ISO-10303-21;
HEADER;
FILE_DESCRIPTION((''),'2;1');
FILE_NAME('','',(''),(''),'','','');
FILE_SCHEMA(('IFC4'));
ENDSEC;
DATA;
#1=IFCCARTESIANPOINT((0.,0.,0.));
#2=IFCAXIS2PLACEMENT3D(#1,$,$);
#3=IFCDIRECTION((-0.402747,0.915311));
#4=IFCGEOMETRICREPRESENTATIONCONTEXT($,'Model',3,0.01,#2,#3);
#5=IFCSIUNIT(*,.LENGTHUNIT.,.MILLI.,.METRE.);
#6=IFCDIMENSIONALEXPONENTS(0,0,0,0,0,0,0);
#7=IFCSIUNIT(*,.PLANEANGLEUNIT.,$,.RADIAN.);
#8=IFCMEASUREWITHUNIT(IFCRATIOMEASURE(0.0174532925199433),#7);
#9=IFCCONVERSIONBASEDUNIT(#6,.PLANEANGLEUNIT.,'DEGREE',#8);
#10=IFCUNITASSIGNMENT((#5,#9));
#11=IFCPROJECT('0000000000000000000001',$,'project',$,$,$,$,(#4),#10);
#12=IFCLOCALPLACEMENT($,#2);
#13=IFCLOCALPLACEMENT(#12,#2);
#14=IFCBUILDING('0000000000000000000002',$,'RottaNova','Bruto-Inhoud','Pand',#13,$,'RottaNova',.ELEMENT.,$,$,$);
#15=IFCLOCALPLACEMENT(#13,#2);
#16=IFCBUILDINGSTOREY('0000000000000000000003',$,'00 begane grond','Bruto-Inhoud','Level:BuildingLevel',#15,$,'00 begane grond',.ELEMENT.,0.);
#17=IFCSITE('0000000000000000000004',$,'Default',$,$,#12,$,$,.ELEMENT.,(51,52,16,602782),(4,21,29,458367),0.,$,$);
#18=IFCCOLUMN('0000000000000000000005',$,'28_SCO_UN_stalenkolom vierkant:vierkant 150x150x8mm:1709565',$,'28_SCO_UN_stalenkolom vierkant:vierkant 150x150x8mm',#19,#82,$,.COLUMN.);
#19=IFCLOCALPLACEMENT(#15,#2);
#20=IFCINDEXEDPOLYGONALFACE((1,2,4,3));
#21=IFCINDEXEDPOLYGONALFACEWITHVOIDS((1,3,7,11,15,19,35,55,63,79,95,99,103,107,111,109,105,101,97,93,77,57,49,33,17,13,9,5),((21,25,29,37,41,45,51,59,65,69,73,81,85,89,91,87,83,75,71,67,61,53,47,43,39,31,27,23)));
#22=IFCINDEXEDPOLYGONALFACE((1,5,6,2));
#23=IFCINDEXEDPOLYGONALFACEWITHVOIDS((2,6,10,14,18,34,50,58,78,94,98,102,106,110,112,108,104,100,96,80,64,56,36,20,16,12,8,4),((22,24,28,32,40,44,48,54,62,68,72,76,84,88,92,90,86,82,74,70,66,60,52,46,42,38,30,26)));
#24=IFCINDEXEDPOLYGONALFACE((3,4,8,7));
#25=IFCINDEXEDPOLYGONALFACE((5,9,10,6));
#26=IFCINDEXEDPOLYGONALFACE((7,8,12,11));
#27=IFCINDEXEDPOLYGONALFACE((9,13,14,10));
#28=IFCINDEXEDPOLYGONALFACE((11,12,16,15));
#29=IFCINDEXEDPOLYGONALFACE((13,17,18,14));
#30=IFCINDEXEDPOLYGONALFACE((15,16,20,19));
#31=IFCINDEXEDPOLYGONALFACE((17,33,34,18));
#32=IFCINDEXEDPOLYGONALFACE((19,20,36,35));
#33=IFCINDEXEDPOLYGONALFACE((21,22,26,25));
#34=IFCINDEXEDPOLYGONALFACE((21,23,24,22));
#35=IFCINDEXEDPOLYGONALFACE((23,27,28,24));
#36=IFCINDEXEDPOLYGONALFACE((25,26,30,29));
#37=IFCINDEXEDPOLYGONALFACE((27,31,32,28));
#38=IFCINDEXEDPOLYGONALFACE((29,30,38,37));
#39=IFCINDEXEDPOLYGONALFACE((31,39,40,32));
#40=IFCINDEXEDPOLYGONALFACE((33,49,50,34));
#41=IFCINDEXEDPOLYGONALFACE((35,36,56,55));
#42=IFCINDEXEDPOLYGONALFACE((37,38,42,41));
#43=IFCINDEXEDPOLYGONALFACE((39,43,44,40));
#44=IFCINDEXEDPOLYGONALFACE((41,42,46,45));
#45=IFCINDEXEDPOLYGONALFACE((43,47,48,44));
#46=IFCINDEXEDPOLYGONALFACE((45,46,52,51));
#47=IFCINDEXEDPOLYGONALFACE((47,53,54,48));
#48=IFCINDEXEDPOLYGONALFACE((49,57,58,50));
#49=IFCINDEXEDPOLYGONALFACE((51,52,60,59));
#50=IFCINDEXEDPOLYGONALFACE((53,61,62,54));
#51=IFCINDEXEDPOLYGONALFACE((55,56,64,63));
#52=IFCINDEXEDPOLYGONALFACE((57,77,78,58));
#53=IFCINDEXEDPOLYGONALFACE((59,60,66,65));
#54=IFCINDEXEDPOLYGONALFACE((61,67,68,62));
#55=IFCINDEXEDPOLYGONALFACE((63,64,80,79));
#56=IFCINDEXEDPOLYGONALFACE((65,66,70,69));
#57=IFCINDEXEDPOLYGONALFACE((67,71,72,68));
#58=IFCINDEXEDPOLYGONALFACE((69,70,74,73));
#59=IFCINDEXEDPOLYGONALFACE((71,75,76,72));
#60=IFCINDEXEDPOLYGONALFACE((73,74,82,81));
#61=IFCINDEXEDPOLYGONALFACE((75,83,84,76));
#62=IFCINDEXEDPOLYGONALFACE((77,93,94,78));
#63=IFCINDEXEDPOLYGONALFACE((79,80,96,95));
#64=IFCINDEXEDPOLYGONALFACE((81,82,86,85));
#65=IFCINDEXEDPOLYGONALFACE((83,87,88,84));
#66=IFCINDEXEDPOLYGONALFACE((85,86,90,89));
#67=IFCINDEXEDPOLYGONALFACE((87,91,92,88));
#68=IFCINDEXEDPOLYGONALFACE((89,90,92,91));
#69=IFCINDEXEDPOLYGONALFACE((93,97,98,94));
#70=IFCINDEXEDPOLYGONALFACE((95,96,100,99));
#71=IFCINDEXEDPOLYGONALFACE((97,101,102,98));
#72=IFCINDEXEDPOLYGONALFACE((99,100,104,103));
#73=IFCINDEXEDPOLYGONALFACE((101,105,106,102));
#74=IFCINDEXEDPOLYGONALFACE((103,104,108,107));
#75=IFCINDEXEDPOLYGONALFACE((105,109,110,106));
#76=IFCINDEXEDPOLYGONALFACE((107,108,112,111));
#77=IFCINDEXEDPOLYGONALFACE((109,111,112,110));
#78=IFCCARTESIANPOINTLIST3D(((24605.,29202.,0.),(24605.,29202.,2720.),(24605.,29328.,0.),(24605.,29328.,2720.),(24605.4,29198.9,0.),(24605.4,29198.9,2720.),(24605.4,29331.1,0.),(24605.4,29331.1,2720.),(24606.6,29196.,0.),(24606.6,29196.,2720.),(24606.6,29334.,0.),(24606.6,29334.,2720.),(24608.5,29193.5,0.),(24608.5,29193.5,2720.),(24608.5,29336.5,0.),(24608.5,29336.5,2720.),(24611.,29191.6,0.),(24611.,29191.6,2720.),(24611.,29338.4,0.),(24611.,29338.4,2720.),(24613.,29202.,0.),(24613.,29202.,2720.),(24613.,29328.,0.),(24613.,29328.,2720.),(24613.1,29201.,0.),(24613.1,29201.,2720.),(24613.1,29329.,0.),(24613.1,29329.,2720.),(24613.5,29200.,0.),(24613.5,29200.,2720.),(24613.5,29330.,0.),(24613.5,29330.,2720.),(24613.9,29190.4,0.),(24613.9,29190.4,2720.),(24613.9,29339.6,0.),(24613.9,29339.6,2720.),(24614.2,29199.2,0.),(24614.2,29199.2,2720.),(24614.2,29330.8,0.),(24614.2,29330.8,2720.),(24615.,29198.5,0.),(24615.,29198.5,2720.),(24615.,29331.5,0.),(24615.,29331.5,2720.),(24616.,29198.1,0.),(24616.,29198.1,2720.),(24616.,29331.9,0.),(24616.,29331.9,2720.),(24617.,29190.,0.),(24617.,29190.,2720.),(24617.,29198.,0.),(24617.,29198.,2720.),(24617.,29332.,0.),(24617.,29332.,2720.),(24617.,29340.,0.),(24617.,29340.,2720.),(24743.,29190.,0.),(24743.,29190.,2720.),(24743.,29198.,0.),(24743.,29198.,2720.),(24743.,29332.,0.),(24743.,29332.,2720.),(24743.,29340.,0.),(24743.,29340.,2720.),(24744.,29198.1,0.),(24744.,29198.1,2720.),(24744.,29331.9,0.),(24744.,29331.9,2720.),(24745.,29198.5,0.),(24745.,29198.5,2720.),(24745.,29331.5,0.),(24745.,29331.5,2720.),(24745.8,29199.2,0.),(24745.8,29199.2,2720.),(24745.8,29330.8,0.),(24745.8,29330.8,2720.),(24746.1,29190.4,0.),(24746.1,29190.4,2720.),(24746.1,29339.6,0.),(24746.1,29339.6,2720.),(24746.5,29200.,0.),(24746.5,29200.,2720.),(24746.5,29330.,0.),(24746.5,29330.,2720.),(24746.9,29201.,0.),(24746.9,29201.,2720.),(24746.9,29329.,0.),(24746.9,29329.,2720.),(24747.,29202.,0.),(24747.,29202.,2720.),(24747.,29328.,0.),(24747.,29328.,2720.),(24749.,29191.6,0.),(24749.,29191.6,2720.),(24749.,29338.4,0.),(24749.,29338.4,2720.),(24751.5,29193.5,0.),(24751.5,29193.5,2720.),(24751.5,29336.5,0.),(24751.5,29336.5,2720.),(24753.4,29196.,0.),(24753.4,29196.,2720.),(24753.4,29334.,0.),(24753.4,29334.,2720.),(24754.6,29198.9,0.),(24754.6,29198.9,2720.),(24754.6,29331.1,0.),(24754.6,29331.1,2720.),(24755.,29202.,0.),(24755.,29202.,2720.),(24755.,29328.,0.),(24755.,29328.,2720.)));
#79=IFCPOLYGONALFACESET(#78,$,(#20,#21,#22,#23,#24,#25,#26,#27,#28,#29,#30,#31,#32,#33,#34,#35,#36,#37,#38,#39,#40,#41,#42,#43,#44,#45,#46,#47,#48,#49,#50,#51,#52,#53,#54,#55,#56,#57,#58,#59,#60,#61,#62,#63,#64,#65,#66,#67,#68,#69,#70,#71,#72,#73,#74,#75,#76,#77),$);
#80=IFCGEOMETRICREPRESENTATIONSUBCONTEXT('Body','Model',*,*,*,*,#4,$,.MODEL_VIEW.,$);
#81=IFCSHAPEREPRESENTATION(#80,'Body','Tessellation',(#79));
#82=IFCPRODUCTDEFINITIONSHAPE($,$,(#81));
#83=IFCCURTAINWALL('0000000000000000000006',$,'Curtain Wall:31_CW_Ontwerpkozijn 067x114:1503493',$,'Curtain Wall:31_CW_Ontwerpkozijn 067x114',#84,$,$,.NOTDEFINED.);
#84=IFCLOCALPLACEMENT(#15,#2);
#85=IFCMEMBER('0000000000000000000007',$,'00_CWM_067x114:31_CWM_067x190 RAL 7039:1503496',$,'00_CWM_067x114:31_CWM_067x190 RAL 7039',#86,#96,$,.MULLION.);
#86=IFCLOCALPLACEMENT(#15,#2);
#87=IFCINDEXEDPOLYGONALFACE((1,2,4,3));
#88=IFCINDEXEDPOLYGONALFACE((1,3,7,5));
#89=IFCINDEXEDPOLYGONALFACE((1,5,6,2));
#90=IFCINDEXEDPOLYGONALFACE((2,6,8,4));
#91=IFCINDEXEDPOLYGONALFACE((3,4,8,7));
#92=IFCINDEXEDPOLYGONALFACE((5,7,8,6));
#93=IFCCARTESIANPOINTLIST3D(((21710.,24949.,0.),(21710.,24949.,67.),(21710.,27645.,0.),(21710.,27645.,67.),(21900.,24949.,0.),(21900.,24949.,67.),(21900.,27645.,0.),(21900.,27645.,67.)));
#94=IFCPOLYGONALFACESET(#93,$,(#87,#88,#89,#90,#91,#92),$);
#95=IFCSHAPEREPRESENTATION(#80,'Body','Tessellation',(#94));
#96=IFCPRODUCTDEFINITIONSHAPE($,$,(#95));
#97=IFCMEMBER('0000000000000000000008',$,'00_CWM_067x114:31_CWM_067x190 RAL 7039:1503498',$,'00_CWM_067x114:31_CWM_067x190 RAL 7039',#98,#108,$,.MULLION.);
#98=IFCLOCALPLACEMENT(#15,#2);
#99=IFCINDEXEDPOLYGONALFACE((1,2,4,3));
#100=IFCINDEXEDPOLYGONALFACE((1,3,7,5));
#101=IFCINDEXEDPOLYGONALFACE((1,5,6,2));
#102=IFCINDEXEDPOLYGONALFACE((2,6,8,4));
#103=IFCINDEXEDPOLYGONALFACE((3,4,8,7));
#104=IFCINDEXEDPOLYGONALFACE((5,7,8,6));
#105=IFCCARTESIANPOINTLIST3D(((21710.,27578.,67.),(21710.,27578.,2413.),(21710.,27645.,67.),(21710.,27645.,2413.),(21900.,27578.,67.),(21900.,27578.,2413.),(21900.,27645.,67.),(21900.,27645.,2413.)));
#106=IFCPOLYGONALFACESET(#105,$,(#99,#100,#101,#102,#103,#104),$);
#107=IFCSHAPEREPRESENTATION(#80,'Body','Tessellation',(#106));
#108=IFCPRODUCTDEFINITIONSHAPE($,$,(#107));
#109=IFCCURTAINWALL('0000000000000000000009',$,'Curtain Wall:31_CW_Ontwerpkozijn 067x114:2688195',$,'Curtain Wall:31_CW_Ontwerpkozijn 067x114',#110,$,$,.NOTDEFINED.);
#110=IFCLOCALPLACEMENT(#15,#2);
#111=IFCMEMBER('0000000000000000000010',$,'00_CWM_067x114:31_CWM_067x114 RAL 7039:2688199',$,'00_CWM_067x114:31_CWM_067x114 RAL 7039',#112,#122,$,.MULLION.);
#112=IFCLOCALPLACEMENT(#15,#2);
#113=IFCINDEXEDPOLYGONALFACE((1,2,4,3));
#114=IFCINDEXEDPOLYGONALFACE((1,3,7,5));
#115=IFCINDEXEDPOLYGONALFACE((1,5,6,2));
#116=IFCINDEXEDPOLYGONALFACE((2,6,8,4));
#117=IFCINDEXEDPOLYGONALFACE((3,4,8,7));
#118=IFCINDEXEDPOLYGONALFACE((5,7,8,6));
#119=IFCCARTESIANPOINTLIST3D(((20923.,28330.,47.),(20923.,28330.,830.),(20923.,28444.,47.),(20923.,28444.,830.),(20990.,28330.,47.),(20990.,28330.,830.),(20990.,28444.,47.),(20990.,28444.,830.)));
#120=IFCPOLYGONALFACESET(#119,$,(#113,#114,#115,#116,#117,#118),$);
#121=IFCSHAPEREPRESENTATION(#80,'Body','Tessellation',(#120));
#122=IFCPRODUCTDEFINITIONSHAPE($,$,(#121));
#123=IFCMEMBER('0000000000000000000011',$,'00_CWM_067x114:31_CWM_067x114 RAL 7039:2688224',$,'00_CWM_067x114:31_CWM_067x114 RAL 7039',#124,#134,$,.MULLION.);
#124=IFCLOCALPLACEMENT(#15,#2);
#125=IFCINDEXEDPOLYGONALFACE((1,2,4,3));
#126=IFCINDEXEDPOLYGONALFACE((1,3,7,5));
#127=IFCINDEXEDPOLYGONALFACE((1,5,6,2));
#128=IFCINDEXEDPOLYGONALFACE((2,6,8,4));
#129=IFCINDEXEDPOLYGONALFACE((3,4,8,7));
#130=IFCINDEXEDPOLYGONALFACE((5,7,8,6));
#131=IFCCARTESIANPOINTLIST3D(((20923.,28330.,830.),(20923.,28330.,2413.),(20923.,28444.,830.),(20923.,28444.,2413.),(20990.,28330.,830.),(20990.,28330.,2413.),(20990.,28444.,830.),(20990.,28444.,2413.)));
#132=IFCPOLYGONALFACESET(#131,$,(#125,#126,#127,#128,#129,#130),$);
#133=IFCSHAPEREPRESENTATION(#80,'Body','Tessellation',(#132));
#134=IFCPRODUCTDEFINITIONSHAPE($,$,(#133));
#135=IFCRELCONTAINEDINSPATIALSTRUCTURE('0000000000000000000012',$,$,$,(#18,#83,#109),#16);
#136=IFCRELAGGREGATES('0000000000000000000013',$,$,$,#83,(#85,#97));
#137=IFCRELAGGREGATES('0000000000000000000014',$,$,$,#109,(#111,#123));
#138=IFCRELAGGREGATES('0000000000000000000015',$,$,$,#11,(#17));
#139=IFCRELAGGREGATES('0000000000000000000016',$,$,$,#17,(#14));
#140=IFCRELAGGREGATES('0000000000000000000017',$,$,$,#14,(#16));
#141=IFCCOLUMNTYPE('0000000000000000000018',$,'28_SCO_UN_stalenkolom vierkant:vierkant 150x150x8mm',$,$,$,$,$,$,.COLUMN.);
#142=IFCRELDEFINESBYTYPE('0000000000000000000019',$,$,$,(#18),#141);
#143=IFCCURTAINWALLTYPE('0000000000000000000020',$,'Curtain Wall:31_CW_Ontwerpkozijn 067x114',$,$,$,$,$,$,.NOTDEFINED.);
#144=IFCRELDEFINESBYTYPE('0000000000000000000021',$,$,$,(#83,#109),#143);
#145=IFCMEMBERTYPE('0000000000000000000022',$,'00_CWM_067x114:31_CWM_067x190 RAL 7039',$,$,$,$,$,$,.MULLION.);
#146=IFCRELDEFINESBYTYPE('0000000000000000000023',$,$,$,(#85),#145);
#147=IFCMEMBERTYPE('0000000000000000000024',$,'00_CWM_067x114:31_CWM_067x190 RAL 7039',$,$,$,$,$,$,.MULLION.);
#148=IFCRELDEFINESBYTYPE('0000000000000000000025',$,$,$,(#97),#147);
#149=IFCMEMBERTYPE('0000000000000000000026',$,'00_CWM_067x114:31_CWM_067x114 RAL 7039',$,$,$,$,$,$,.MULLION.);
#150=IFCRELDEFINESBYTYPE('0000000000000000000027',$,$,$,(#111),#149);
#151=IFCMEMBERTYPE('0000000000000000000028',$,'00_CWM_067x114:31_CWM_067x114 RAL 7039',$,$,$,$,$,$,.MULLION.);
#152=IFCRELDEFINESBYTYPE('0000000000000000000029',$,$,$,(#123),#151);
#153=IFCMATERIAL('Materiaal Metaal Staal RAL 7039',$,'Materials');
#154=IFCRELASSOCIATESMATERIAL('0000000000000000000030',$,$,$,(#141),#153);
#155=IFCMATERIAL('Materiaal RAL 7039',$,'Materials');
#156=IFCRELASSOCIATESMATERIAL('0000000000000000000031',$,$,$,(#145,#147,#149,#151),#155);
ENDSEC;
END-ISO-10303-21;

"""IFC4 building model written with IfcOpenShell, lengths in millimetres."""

from ifc_helpers import new_model, entity, si_unit, converted_unit, direction, frame, frame_2d, origin, origin_2d_with_axis, place, context, subcontext, project, spatial, polyline, circle_curve, parameter, trimmed, segment, composite_curve, rectangle, outline, extrude, source, transform, mapped, material, material_profile, profile_set, type_object, type_shapes, element, aggregate, save


model = new_model("IFC4")

# Units and contexts
model_context = context("Model", 3, precision=0.01, world=origin(), true_north=direction((-0.402747, 0.915311)))
body_context = subcontext(model_context, "Body", "Model", "MODEL_VIEW")
ifc_project = project(units=[si_unit("LENGTHUNIT", "METRE", prefix="MILLI"), converted_unit("PLANEANGLEUNIT", "DEGREE", entity("IfcRatioMeasure", 0.0174532925199433), si_unit("PLANEANGLEUNIT", "RADIAN"), dimensions=[0, 0, 0, 0, 0, 0, 0])], contexts=[model_context])

# Site, building, storey
site_placement = place(None, origin())
site = spatial("IfcSite", under=ifc_project, at=site_placement, Name="Default", CompositionType="ELEMENT", RefLatitude=(51, 52, 16, 602782), RefLongitude=(4, 21, 29, 458367), RefElevation=0.0)
building_placement = place(site_placement, origin())
building = spatial("IfcBuilding", under=site, at=building_placement, Name="RottaNova", Description="Bruto-Inhoud", ObjectType="Pand", LongName="RottaNova", CompositionType="ELEMENT")
storey_placement = place(building_placement, origin())
storey = spatial("IfcBuildingStorey", under=building, at=storey_placement, Name="00 begane grond", Description="Bruto-Inhoud", ObjectType="Level:BuildingLevel", LongName="00 begane grond", CompositionType="ELEMENT", Elevation=0.0)

# Column
ifc_material_1 = material(Name="Materiaal Metaal Staal RAL 7039", Category="Materials")
ifc_material_profile_1 = material_profile(ifc_material_1, outline(composite_curve([segment(trimmed(circle_curve(frame_2d((63.0, -63.0), x_axis=(1.0, 0.0)), 12.0), [parameter(270.0)], [parameter(360.0)], True, "PARAMETER"), True, "CONTINUOUS"), segment(polyline([(75.0, -63.0), (75.0, 63.0)]), True, "CONTINUOUS"), segment(trimmed(circle_curve(frame_2d((63.0, 63.0), x_axis=(1.0, 0.0)), 12.0), [parameter(360.0)], [parameter(90.0)], True, "PARAMETER"), True, "CONTINUOUS"), segment(polyline([(63.0, 75.0), (-63.0, 75.0)]), True, "CONTINUOUS"), segment(trimmed(circle_curve(frame_2d((-63.0, 63.0), x_axis=(1.0, 0.0)), 12.0), [parameter(90.0)], [parameter(180.0)], True, "PARAMETER"), True, "CONTINUOUS"), segment(polyline([(-75.0, 63.0), (-75.0, -63.0)]), True, "CONTINUOUS"), segment(trimmed(circle_curve(frame_2d((-63.0, -63.0), x_axis=(1.0, 0.0)), 12.0), [parameter(180.0)], [parameter(270.0)], True, "PARAMETER"), True, "CONTINUOUS"), segment(polyline([(-63.0, -75.0), (63.0, -75.0)]), True, "CONTINUOUS")], self_intersect=False), holes=[composite_curve([segment(polyline([(-67.0, -63.0), (-67.0, 63.0)]), True, "CONTINUOUS"), segment(trimmed(circle_curve(frame_2d((-63.0, 63.0), x_axis=(1.0, 0.0)), 4.0), [parameter(90.0)], [parameter(180.0)], True, "PARAMETER"), False, "CONTINUOUS"), segment(polyline([(-63.0, 67.0), (63.0, 67.0)]), True, "CONTINUOUS"), segment(trimmed(circle_curve(frame_2d((63.0, 63.0), x_axis=(1.0, 0.0)), 4.0), [parameter(0.0)], [parameter(90.0)], True, "PARAMETER"), False, "CONTINUOUS"), segment(polyline([(67.0, 63.0), (67.0, -63.0)]), True, "CONTINUOUS"), segment(trimmed(circle_curve(frame_2d((63.0, -63.0), x_axis=(1.0, 0.0)), 4.0), [parameter(270.0)], [parameter(0.0)], True, "PARAMETER"), False, "CONTINUOUS"), segment(polyline([(63.0, -67.0), (-63.0, -67.0)]), True, "CONTINUOUS"), segment(trimmed(circle_curve(frame_2d((-63.0, -63.0), x_axis=(1.0, 0.0)), 4.0), [parameter(180.0)], [parameter(270.0)], True, "PARAMETER"), False, "CONTINUOUS")], self_intersect=False)]), Name="vierkant 150x150x8mm")
ifc_profile_set_1 = profile_set([ifc_material_profile_1], Name="vierkant 150x150x8mm")
column_type = type_object("IfcColumnType", Name="28_SCO_UN_stalenkolom vierkant:vierkant 150x150x8mm", PredefinedType="COLUMN", material=ifc_profile_set_1)
shared_shape_1 = source(origin(), body_context, "Body", "SweptSolid", [
    extrude(outline(composite_curve([segment(polyline([(-63.0, -75.0), (63.0, -75.0)]), True, "CONTINUOUS"), segment(trimmed(circle_curve(frame_2d((63.0, -63.0), x_axis=(-1.0, 0.0)), 12.0), [parameter(90.0)], [parameter(180.0)], True, "PARAMETER"), True, "CONTINUOUS"), segment(polyline([(75.0, -63.0), (75.0, 63.0)]), True, "CONTINUOUS"), segment(trimmed(circle_curve(frame_2d((63.0, 63.0), x_axis=(-1.0, 0.0)), 12.0), [parameter(180.0)], [parameter(270.0)], True, "PARAMETER"), True, "CONTINUOUS"), segment(polyline([(63.0, 75.0), (-63.0, 75.0)]), True, "CONTINUOUS"), segment(trimmed(circle_curve(frame_2d((-63.0, 63.0), x_axis=(-1.0, 0.0)), 12.0), [parameter(270.0)], [parameter(0.0)], True, "PARAMETER"), True, "CONTINUOUS"), segment(polyline([(-75.0, 63.0), (-75.0, -63.0)]), True, "CONTINUOUS"), segment(trimmed(circle_curve(frame_2d((-63.0, -63.0), x_axis=(-1.0, 0.0)), 12.0), [parameter(0.0)], [parameter(90.0)], True, "PARAMETER"), True, "CONTINUOUS")], self_intersect=False), holes=[composite_curve([segment(trimmed(circle_curve(frame_2d((63.0, -63.0), x_axis=(-1.0, 0.0)), 4.0), [parameter(90.0)], [parameter(180.0)], True, "PARAMETER"), False, "CONTINUOUS"), segment(polyline([(63.0, -67.0), (-63.0, -67.0)]), True, "CONTINUOUS"), segment(trimmed(circle_curve(frame_2d((-63.0, -63.0), x_axis=(-1.0, 0.0)), 4.0), [parameter(0.0)], [parameter(90.0)], True, "PARAMETER"), False, "CONTINUOUS"), segment(polyline([(-67.0, -63.0), (-67.0, 63.0)]), True, "CONTINUOUS"), segment(trimmed(circle_curve(frame_2d((-63.0, 63.0), x_axis=(-1.0, 0.0)), 4.0), [parameter(270.0)], [parameter(360.0)], True, "PARAMETER"), False, "CONTINUOUS"), segment(polyline([(-63.0, 67.0), (63.0, 67.0)]), True, "CONTINUOUS"), segment(trimmed(circle_curve(frame_2d((63.0, 63.0), x_axis=(-1.0, 0.0)), 4.0), [parameter(180.0)], [parameter(270.0)], True, "PARAMETER"), False, "CONTINUOUS"), segment(polyline([(67.0, 63.0), (67.0, -63.0)]), True, "CONTINUOUS")], self_intersect=False)]), frame((0.0, 0.0, 0.0), z_axis=(0.0, 0.0, 1.0), x_axis=(-1.0, 0.0, 0.0)), (0.0, 0.0, 1.0), 2720.0),
])
type_shapes(column_type, [shared_shape_1])
column_placement = place(storey_placement, frame((24680.0, 29265.0, 0.0)))
element("IfcColumn", 1, at=column_placement, inside=storey, type_object=column_type, Name="28_SCO_UN_stalenkolom vierkant:vierkant 150x150x8mm:1709565", ObjectType="28_SCO_UN_stalenkolom vierkant:vierkant 150x150x8mm", PredefinedType="COLUMN", context=body_context, shape_type="MappedRepresentation", body=[
    mapped(shared_shape_1, transform((0.0, 0.0, 0.0), scale=1.0)),
])

# Curtain walls, members
curtain_wall_type = type_object("IfcCurtainWallType", Name="Curtain Wall:31_CW_Ontwerpkozijn 067x114", PredefinedType="NOTDEFINED")
curtain_wall_1_placement = place(storey_placement, origin())
curtain_wall_1 = element("IfcCurtainWall", 2, at=curtain_wall_1_placement, inside=storey, type_object=curtain_wall_type, Name="Curtain Wall:31_CW_Ontwerpkozijn 067x114:1503493", ObjectType="Curtain Wall:31_CW_Ontwerpkozijn 067x114", PredefinedType="NOTDEFINED")
ifc_material_2 = material(Name="Materiaal RAL 7039", Category="Materials")
ifc_material_profile_2 = material_profile(ifc_material_2, rectangle(XDim=190.0, YDim=67.0, at=origin_2d_with_axis()), Name="31_CWM_067x190 RAL 7039")
ifc_profile_set_2 = profile_set([ifc_material_profile_2], Name="31_CWM_067x190 RAL 7039")
member_type_1 = type_object("IfcMemberType", Name="00_CWM_067x114:31_CWM_067x190 RAL 7039", PredefinedType="MULLION", material=ifc_profile_set_2)
shared_shape_2 = source(origin(), body_context, "Body", "SweptSolid", [
    extrude(rectangle(XDim=190.0, YDim=67.0, at=origin_2d_with_axis()), frame((-33.5, -95.0, -2696.0), z_axis=(0.0, 0.0, 1.0), x_axis=(0.0, -1.0, 0.0)), (0.0, 0.0, 1.0), 2696.0),
])
type_shapes(member_type_1, [shared_shape_2])
member_1_placement = place(curtain_wall_1_placement, frame((21710.0, 27645.0, 0.0), z_axis=(0.0, 1.0, 0.0), x_axis=(0.0, 0.0, -1.0)))
member_1 = element("IfcMember", 3, at=member_1_placement, type_object=member_type_1, Name="00_CWM_067x114:31_CWM_067x190 RAL 7039:1503496", ObjectType="00_CWM_067x114:31_CWM_067x190 RAL 7039", PredefinedType="MULLION", context=body_context, shape_type="MappedRepresentation", body=[
    mapped(shared_shape_2, transform((0.0, 0.0, 0.0), scale=1.0)),
])
member_type_2 = type_object("IfcMemberType", Name="00_CWM_067x114:31_CWM_067x190 RAL 7039", PredefinedType="MULLION", material=ifc_profile_set_2)
shared_shape_3 = source(origin(), body_context, "Body", "SweptSolid", [
    extrude(rectangle(XDim=190.0, YDim=67.0, at=origin_2d_with_axis()), frame((-33.5, -95.0, -2346.0), z_axis=(0.0, 0.0, 1.0), x_axis=(0.0, -1.0, 0.0)), (0.0, 0.0, 1.0), 2346.0),
])
type_shapes(member_type_2, [shared_shape_3])
member_2_placement = place(curtain_wall_1_placement, frame((21710.0, 27645.0, 2413.0), z_axis=(0.0, 0.0, 1.0), x_axis=(0.0, 1.0, 0.0)))
member_2 = element("IfcMember", 4, at=member_2_placement, type_object=member_type_2, Name="00_CWM_067x114:31_CWM_067x190 RAL 7039:1503498", ObjectType="00_CWM_067x114:31_CWM_067x190 RAL 7039", PredefinedType="MULLION", context=body_context, shape_type="MappedRepresentation", body=[
    mapped(shared_shape_3, transform((0.0, 0.0, 0.0), scale=1.0)),
])
aggregate(curtain_wall_1, [member_1, member_2])
curtain_wall_2_placement = place(storey_placement, origin())
curtain_wall_2 = element("IfcCurtainWall", 5, at=curtain_wall_2_placement, inside=storey, type_object=curtain_wall_type, Name="Curtain Wall:31_CW_Ontwerpkozijn 067x114:2688195", ObjectType="Curtain Wall:31_CW_Ontwerpkozijn 067x114", PredefinedType="NOTDEFINED")
ifc_material_profile_3 = material_profile(ifc_material_2, rectangle(XDim=114.0, YDim=67.0, at=origin_2d_with_axis()), Name="31_CWM_067x114 RAL 7039")
ifc_profile_set_3 = profile_set([ifc_material_profile_3], Name="31_CWM_067x114 RAL 7039")
member_type_3 = type_object("IfcMemberType", Name="00_CWM_067x114:31_CWM_067x114 RAL 7039", PredefinedType="MULLION", material=ifc_profile_set_3)
shared_shape_4 = source(origin(), body_context, "Body", "SweptSolid", [
    extrude(rectangle(XDim=114.0, YDim=67.0, at=frame_2d((0.0, 0.0), x_axis=(1.0, 0.0))), frame((-33.5, -57.0, -783.0), z_axis=(0.0, 0.0, 1.0), x_axis=(0.0, -1.0, 0.0)), (0.0, 0.0, 1.0), 783.0),
])
type_shapes(member_type_3, [shared_shape_4])
member_3_placement = place(curtain_wall_2_placement, frame((20990.0, 28330.0, 47.0), z_axis=(0.0, 0.0, -1.0), x_axis=(1.0, 0.0, 0.0)))
member_3 = element("IfcMember", 6, at=member_3_placement, type_object=member_type_3, Name="00_CWM_067x114:31_CWM_067x114 RAL 7039:2688199", ObjectType="00_CWM_067x114:31_CWM_067x114 RAL 7039", PredefinedType="MULLION", context=body_context, shape_type="MappedRepresentation", body=[
    mapped(shared_shape_4, transform((0.0, 0.0, 0.0), scale=1.0)),
])
member_type_4 = type_object("IfcMemberType", Name="00_CWM_067x114:31_CWM_067x114 RAL 7039", PredefinedType="MULLION", material=ifc_profile_set_3)
shared_shape_5 = source(origin(), body_context, "Body", "SweptSolid", [
    extrude(rectangle(XDim=114.0, YDim=67.0, at=frame_2d((0.0, 0.0), x_axis=(1.0, 0.0))), frame((-33.5, -57.0, -1583.0), z_axis=(0.0, 0.0, 1.0), x_axis=(0.0, -1.0, 0.0)), (0.0, 0.0, 1.0), 1583.0),
])
type_shapes(member_type_4, [shared_shape_5])
member_4_placement = place(curtain_wall_2_placement, frame((20990.0, 28330.0, 830.0), z_axis=(0.0, 0.0, -1.0), x_axis=(1.0, 0.0, 0.0)))
member_4 = element("IfcMember", 7, at=member_4_placement, type_object=member_type_4, Name="00_CWM_067x114:31_CWM_067x114 RAL 7039:2688224", ObjectType="00_CWM_067x114:31_CWM_067x114 RAL 7039", PredefinedType="MULLION", context=body_context, shape_type="MappedRepresentation", body=[
    mapped(shared_shape_5, transform((0.0, 0.0, 0.0), scale=1.0)),
])
aggregate(curtain_wall_2, [member_3, member_4])

save(model, "model.ifc")
